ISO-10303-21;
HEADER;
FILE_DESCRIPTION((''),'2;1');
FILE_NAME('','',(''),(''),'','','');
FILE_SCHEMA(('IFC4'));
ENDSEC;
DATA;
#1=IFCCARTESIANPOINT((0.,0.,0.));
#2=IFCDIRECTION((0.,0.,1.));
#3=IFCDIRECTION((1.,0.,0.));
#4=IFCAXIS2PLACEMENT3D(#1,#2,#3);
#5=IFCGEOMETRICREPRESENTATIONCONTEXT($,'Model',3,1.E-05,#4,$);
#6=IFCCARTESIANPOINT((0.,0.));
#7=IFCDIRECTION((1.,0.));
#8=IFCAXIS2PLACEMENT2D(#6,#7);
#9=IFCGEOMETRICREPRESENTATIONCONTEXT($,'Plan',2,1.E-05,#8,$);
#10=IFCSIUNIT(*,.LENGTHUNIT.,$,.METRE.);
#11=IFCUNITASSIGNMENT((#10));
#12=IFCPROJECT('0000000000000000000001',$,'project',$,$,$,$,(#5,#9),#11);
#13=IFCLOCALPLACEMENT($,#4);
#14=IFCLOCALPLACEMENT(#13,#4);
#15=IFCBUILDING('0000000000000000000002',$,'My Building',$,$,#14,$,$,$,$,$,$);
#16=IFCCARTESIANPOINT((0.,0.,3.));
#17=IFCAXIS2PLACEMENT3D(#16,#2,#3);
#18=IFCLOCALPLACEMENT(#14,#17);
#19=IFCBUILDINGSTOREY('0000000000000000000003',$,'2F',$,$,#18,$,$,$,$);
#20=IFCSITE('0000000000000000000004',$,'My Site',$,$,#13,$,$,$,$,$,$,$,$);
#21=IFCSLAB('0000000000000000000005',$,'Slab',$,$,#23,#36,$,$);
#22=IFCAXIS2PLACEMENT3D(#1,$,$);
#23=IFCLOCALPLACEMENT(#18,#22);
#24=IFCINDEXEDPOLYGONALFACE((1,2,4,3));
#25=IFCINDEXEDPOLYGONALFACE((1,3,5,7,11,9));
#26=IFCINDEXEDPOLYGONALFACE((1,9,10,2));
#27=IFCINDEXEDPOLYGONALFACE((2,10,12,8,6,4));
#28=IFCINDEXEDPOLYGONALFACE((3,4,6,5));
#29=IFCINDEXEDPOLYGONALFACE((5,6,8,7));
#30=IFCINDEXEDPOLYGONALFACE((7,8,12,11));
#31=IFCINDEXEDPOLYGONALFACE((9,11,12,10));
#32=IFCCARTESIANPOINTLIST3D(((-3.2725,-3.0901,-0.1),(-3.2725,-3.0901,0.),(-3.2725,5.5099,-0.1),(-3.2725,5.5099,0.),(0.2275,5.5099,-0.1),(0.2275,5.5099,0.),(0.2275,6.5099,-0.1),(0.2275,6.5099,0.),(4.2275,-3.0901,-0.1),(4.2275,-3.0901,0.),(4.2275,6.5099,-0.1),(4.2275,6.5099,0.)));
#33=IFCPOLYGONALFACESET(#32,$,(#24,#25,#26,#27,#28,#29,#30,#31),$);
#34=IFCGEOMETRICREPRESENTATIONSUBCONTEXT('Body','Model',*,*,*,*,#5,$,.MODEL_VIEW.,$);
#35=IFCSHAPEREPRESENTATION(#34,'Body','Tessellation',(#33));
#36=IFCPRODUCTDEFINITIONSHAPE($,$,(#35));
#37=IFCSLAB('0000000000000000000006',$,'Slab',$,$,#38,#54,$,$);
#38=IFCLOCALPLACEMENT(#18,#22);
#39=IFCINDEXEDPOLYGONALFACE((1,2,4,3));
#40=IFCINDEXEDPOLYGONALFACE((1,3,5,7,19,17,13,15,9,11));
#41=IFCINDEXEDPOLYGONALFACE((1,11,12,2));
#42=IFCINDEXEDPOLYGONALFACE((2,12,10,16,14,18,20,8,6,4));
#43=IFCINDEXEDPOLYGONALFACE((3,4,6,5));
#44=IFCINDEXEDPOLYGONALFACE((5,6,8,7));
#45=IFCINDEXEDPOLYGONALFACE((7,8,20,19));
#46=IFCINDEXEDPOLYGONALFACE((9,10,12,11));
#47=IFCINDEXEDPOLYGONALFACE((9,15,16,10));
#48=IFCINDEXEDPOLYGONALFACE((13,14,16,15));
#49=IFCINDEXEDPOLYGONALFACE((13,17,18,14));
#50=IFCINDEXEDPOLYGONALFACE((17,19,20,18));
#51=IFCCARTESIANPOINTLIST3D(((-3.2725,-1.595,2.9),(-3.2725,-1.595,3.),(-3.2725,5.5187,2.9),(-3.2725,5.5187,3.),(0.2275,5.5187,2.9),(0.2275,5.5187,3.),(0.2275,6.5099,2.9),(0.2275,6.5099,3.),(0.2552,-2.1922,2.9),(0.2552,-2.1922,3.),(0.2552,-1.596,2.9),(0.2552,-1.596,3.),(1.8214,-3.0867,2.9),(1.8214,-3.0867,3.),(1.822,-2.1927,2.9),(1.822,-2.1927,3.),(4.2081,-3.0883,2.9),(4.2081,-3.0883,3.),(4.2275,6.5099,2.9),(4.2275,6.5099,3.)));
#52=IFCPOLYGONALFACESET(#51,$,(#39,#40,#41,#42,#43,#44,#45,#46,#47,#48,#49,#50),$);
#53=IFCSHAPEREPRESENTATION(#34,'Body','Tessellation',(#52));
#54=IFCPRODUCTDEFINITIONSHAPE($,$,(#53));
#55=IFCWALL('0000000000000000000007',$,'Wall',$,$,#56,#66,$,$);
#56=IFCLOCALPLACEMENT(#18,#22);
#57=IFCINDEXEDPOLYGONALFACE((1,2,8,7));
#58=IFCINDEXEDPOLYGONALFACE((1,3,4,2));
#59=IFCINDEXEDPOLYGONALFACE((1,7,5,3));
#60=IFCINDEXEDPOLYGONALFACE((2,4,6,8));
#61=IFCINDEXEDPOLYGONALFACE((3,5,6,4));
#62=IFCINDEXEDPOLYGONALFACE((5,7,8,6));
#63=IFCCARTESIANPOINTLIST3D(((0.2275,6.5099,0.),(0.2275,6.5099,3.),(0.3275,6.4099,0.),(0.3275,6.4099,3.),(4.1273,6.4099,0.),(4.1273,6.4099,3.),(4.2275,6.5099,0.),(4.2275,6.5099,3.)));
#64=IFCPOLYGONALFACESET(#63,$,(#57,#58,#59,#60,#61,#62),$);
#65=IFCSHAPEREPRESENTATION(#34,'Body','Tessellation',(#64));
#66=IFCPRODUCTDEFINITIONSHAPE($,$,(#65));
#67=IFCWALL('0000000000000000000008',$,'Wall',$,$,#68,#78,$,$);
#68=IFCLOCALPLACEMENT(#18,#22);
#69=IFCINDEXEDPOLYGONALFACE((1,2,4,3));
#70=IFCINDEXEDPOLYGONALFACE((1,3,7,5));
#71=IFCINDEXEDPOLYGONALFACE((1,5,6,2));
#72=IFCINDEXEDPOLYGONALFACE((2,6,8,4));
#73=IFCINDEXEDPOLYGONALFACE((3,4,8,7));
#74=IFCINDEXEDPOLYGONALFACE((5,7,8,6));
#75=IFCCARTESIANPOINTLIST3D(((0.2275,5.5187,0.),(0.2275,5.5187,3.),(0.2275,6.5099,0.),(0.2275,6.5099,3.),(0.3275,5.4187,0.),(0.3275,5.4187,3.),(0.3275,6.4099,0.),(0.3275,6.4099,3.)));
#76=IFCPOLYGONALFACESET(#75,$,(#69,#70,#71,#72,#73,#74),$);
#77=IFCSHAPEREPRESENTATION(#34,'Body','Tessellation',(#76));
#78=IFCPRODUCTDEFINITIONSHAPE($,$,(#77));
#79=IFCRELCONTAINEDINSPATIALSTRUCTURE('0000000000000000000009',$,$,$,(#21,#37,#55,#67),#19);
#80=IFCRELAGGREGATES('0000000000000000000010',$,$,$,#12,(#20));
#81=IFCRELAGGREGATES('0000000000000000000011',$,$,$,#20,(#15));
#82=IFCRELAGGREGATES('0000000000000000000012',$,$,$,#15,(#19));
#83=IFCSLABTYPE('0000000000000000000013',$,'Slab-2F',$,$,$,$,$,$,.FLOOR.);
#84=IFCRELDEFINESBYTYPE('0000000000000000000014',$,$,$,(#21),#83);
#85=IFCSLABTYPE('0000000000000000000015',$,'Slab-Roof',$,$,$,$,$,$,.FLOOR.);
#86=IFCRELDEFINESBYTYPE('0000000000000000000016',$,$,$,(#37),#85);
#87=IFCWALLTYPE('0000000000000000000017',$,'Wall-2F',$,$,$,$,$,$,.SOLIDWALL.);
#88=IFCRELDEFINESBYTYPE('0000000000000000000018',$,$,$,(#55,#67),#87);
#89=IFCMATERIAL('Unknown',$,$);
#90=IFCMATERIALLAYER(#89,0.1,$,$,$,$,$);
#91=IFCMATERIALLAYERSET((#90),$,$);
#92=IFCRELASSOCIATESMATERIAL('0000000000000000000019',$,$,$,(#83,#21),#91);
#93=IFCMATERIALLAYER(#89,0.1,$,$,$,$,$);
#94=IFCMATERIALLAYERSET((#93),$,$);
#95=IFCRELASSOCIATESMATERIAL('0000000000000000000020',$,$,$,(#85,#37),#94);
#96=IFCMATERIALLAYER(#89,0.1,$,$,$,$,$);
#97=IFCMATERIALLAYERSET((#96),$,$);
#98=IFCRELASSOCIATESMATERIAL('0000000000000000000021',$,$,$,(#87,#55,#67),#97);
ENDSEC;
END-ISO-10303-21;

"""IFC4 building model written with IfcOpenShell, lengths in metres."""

from ifc_helpers import new_model, si_unit, frame, origin_with_axes, origin_2d_with_axis, place, context, subcontext, project, spatial, line, indexed_curve, outline, extrude, material, layer, layer_set, layer_usage, type_object, element, save


model = new_model("IFC4")

# Units and contexts
model_context = context("Model", 3, precision=1e-05, world=origin_with_axes())
plan_context = context("Plan", 2, precision=1e-05, world=origin_2d_with_axis())
body_context_1 = subcontext(model_context, "Body", "Model", "MODEL_VIEW")
ifc_project = project(units=[si_unit("LENGTHUNIT", "METRE")], contexts=[model_context, plan_context])

# Site, building, storey
site_placement = place(None, origin_with_axes())
site = spatial("IfcSite", under=ifc_project, at=site_placement, Name="My Site")
building_placement = place(site_placement, origin_with_axes())
building = spatial("IfcBuilding", under=site, at=building_placement, Name="My Building")
storey_placement = place(building_placement, frame((0.0, 0.0, 3.0), z_axis=(0.0, 0.0, 1.0), x_axis=(1.0, 0.0, 0.0)))
storey = spatial("IfcBuildingStorey", under=building, at=storey_placement, Name="2F")

# Slabs
ifc_material_1 = material(Name="Unknown")
ifc_layer_1 = layer(ifc_material_1, 0.1)
ifc_layer_set_1 = layer_set([ifc_layer_1])
ifc_layer_usage_1 = layer_usage(ifc_layer_set_1, "AXIS3", "POSITIVE", -0.1)
slab_type_1 = type_object("IfcSlabType", Name="Slab-2F", PredefinedType="FLOOR", material=ifc_layer_set_1)
slab_1_placement = place(storey_placement, frame((4.2275, 6.5099, 0.0), z_axis=(0.0, 0.0, 1.0), x_axis=(1.0, 0.0, 0.0)))
element("IfcSlab", 1, at=slab_1_placement, inside=storey, type_object=slab_type_1, material=ifc_layer_usage_1, Name="Slab", context=body_context_1, shape_type="SweptSolid", body=[
    extrude(outline(indexed_curve([(0.0, 0.0), (-4.0, 0.0), (-4.0, -1.0), (-7.5, -1.0), (-7.5, -9.6), (0.0, -9.6), (0.0, 0.0)])), frame((0.0, 0.0, -0.1), z_axis=(0.0, 0.0, 1.0), x_axis=(1.0, 0.0, 0.0)), (0.0, 0.0, 1.0), 0.1),
])
ifc_layer_2 = layer(ifc_material_1, 0.1)
ifc_layer_set_2 = layer_set([ifc_layer_2])
ifc_layer_usage_2 = layer_usage(ifc_layer_set_2, "AXIS3", "POSITIVE", -0.1)
slab_type_2 = type_object("IfcSlabType", Name="Slab-Roof", PredefinedType="FLOOR", material=ifc_layer_set_2)
slab_2_placement = place(storey_placement, frame((4.2275, 6.5099, 3.0), z_axis=(0.0, 0.0, 1.0), x_axis=(1.0, 0.0, 0.0)))
element("IfcSlab", 2, at=slab_2_placement, inside=storey, type_object=slab_type_2, material=ifc_layer_usage_2, Name="Slab", context=body_context_1, shape_type="SweptSolid", body=[
    extrude(outline(indexed_curve([(0.0, 0.0), (-4.0, 0.0), (-4.0, -0.9913), (-7.5, -0.9913), (-7.5, -8.1049), (-3.9723, -8.1059), (-3.9723, -8.7022), (-2.4055, -8.7026), (-2.4061, -9.5967), (-0.0194, -9.5982), (0.0, 0.0)])), frame((0.0, 0.0, -0.1), z_axis=(0.0, 0.0, 1.0), x_axis=(1.0, 0.0, 0.0)), (0.0, 0.0, 1.0), 0.1),
])

# Walls
ifc_layer_3 = layer(ifc_material_1, 0.1)
ifc_layer_set_3 = layer_set([ifc_layer_3])
ifc_layer_usage_3 = layer_usage(ifc_layer_set_3, "AXIS2", "POSITIVE", 0.0)
wall_type = type_object("IfcWallType", Name="Wall-2F", PredefinedType="SOLIDWALL", material=ifc_layer_set_3)
wall_1_placement = place(storey_placement, frame((4.2275, 6.5099, 0.0), z_axis=(0.0, 0.0, 1.0), x_axis=(-1.0, 0.0, 0.0)))
element("IfcWall", 3, at=wall_1_placement, inside=storey, type_object=wall_type, material=ifc_layer_usage_3, Name="Wall", context=body_context_1, shape_type="SweptSolid", body=[
    extrude(outline(indexed_curve([(0.0, 0.0), (0.1002, 0.1), (3.9, 0.1), (4.0, 0.0)], segments=[line(1, 2, 3, 4, 1)])), origin_with_axes(), (0.0, 0.0, 1.0), 3.0),
])
ifc_layer_usage_4 = layer_usage(ifc_layer_set_3, "AXIS2", "POSITIVE", 0.0)
wall_2_placement = place(storey_placement, frame((0.2275, 6.5099, 0.0), z_axis=(0.0, 0.0, 1.0), x_axis=(0.0, -1.0, 0.0)))
element("IfcWall", 4, at=wall_2_placement, inside=storey, type_object=wall_type, material=ifc_layer_usage_4, Name="Wall", context=body_context_1, shape_type="SweptSolid", body=[
    extrude(outline(indexed_curve([(0.0, 0.0), (0.1, 0.1), (1.0913, 0.1), (0.9913, 0.0)], segments=[line(1, 2, 3, 4, 1)])), origin_with_axes(), (0.0, 0.0, 1.0), 3.0),
])

save(model, "model.ifc")
